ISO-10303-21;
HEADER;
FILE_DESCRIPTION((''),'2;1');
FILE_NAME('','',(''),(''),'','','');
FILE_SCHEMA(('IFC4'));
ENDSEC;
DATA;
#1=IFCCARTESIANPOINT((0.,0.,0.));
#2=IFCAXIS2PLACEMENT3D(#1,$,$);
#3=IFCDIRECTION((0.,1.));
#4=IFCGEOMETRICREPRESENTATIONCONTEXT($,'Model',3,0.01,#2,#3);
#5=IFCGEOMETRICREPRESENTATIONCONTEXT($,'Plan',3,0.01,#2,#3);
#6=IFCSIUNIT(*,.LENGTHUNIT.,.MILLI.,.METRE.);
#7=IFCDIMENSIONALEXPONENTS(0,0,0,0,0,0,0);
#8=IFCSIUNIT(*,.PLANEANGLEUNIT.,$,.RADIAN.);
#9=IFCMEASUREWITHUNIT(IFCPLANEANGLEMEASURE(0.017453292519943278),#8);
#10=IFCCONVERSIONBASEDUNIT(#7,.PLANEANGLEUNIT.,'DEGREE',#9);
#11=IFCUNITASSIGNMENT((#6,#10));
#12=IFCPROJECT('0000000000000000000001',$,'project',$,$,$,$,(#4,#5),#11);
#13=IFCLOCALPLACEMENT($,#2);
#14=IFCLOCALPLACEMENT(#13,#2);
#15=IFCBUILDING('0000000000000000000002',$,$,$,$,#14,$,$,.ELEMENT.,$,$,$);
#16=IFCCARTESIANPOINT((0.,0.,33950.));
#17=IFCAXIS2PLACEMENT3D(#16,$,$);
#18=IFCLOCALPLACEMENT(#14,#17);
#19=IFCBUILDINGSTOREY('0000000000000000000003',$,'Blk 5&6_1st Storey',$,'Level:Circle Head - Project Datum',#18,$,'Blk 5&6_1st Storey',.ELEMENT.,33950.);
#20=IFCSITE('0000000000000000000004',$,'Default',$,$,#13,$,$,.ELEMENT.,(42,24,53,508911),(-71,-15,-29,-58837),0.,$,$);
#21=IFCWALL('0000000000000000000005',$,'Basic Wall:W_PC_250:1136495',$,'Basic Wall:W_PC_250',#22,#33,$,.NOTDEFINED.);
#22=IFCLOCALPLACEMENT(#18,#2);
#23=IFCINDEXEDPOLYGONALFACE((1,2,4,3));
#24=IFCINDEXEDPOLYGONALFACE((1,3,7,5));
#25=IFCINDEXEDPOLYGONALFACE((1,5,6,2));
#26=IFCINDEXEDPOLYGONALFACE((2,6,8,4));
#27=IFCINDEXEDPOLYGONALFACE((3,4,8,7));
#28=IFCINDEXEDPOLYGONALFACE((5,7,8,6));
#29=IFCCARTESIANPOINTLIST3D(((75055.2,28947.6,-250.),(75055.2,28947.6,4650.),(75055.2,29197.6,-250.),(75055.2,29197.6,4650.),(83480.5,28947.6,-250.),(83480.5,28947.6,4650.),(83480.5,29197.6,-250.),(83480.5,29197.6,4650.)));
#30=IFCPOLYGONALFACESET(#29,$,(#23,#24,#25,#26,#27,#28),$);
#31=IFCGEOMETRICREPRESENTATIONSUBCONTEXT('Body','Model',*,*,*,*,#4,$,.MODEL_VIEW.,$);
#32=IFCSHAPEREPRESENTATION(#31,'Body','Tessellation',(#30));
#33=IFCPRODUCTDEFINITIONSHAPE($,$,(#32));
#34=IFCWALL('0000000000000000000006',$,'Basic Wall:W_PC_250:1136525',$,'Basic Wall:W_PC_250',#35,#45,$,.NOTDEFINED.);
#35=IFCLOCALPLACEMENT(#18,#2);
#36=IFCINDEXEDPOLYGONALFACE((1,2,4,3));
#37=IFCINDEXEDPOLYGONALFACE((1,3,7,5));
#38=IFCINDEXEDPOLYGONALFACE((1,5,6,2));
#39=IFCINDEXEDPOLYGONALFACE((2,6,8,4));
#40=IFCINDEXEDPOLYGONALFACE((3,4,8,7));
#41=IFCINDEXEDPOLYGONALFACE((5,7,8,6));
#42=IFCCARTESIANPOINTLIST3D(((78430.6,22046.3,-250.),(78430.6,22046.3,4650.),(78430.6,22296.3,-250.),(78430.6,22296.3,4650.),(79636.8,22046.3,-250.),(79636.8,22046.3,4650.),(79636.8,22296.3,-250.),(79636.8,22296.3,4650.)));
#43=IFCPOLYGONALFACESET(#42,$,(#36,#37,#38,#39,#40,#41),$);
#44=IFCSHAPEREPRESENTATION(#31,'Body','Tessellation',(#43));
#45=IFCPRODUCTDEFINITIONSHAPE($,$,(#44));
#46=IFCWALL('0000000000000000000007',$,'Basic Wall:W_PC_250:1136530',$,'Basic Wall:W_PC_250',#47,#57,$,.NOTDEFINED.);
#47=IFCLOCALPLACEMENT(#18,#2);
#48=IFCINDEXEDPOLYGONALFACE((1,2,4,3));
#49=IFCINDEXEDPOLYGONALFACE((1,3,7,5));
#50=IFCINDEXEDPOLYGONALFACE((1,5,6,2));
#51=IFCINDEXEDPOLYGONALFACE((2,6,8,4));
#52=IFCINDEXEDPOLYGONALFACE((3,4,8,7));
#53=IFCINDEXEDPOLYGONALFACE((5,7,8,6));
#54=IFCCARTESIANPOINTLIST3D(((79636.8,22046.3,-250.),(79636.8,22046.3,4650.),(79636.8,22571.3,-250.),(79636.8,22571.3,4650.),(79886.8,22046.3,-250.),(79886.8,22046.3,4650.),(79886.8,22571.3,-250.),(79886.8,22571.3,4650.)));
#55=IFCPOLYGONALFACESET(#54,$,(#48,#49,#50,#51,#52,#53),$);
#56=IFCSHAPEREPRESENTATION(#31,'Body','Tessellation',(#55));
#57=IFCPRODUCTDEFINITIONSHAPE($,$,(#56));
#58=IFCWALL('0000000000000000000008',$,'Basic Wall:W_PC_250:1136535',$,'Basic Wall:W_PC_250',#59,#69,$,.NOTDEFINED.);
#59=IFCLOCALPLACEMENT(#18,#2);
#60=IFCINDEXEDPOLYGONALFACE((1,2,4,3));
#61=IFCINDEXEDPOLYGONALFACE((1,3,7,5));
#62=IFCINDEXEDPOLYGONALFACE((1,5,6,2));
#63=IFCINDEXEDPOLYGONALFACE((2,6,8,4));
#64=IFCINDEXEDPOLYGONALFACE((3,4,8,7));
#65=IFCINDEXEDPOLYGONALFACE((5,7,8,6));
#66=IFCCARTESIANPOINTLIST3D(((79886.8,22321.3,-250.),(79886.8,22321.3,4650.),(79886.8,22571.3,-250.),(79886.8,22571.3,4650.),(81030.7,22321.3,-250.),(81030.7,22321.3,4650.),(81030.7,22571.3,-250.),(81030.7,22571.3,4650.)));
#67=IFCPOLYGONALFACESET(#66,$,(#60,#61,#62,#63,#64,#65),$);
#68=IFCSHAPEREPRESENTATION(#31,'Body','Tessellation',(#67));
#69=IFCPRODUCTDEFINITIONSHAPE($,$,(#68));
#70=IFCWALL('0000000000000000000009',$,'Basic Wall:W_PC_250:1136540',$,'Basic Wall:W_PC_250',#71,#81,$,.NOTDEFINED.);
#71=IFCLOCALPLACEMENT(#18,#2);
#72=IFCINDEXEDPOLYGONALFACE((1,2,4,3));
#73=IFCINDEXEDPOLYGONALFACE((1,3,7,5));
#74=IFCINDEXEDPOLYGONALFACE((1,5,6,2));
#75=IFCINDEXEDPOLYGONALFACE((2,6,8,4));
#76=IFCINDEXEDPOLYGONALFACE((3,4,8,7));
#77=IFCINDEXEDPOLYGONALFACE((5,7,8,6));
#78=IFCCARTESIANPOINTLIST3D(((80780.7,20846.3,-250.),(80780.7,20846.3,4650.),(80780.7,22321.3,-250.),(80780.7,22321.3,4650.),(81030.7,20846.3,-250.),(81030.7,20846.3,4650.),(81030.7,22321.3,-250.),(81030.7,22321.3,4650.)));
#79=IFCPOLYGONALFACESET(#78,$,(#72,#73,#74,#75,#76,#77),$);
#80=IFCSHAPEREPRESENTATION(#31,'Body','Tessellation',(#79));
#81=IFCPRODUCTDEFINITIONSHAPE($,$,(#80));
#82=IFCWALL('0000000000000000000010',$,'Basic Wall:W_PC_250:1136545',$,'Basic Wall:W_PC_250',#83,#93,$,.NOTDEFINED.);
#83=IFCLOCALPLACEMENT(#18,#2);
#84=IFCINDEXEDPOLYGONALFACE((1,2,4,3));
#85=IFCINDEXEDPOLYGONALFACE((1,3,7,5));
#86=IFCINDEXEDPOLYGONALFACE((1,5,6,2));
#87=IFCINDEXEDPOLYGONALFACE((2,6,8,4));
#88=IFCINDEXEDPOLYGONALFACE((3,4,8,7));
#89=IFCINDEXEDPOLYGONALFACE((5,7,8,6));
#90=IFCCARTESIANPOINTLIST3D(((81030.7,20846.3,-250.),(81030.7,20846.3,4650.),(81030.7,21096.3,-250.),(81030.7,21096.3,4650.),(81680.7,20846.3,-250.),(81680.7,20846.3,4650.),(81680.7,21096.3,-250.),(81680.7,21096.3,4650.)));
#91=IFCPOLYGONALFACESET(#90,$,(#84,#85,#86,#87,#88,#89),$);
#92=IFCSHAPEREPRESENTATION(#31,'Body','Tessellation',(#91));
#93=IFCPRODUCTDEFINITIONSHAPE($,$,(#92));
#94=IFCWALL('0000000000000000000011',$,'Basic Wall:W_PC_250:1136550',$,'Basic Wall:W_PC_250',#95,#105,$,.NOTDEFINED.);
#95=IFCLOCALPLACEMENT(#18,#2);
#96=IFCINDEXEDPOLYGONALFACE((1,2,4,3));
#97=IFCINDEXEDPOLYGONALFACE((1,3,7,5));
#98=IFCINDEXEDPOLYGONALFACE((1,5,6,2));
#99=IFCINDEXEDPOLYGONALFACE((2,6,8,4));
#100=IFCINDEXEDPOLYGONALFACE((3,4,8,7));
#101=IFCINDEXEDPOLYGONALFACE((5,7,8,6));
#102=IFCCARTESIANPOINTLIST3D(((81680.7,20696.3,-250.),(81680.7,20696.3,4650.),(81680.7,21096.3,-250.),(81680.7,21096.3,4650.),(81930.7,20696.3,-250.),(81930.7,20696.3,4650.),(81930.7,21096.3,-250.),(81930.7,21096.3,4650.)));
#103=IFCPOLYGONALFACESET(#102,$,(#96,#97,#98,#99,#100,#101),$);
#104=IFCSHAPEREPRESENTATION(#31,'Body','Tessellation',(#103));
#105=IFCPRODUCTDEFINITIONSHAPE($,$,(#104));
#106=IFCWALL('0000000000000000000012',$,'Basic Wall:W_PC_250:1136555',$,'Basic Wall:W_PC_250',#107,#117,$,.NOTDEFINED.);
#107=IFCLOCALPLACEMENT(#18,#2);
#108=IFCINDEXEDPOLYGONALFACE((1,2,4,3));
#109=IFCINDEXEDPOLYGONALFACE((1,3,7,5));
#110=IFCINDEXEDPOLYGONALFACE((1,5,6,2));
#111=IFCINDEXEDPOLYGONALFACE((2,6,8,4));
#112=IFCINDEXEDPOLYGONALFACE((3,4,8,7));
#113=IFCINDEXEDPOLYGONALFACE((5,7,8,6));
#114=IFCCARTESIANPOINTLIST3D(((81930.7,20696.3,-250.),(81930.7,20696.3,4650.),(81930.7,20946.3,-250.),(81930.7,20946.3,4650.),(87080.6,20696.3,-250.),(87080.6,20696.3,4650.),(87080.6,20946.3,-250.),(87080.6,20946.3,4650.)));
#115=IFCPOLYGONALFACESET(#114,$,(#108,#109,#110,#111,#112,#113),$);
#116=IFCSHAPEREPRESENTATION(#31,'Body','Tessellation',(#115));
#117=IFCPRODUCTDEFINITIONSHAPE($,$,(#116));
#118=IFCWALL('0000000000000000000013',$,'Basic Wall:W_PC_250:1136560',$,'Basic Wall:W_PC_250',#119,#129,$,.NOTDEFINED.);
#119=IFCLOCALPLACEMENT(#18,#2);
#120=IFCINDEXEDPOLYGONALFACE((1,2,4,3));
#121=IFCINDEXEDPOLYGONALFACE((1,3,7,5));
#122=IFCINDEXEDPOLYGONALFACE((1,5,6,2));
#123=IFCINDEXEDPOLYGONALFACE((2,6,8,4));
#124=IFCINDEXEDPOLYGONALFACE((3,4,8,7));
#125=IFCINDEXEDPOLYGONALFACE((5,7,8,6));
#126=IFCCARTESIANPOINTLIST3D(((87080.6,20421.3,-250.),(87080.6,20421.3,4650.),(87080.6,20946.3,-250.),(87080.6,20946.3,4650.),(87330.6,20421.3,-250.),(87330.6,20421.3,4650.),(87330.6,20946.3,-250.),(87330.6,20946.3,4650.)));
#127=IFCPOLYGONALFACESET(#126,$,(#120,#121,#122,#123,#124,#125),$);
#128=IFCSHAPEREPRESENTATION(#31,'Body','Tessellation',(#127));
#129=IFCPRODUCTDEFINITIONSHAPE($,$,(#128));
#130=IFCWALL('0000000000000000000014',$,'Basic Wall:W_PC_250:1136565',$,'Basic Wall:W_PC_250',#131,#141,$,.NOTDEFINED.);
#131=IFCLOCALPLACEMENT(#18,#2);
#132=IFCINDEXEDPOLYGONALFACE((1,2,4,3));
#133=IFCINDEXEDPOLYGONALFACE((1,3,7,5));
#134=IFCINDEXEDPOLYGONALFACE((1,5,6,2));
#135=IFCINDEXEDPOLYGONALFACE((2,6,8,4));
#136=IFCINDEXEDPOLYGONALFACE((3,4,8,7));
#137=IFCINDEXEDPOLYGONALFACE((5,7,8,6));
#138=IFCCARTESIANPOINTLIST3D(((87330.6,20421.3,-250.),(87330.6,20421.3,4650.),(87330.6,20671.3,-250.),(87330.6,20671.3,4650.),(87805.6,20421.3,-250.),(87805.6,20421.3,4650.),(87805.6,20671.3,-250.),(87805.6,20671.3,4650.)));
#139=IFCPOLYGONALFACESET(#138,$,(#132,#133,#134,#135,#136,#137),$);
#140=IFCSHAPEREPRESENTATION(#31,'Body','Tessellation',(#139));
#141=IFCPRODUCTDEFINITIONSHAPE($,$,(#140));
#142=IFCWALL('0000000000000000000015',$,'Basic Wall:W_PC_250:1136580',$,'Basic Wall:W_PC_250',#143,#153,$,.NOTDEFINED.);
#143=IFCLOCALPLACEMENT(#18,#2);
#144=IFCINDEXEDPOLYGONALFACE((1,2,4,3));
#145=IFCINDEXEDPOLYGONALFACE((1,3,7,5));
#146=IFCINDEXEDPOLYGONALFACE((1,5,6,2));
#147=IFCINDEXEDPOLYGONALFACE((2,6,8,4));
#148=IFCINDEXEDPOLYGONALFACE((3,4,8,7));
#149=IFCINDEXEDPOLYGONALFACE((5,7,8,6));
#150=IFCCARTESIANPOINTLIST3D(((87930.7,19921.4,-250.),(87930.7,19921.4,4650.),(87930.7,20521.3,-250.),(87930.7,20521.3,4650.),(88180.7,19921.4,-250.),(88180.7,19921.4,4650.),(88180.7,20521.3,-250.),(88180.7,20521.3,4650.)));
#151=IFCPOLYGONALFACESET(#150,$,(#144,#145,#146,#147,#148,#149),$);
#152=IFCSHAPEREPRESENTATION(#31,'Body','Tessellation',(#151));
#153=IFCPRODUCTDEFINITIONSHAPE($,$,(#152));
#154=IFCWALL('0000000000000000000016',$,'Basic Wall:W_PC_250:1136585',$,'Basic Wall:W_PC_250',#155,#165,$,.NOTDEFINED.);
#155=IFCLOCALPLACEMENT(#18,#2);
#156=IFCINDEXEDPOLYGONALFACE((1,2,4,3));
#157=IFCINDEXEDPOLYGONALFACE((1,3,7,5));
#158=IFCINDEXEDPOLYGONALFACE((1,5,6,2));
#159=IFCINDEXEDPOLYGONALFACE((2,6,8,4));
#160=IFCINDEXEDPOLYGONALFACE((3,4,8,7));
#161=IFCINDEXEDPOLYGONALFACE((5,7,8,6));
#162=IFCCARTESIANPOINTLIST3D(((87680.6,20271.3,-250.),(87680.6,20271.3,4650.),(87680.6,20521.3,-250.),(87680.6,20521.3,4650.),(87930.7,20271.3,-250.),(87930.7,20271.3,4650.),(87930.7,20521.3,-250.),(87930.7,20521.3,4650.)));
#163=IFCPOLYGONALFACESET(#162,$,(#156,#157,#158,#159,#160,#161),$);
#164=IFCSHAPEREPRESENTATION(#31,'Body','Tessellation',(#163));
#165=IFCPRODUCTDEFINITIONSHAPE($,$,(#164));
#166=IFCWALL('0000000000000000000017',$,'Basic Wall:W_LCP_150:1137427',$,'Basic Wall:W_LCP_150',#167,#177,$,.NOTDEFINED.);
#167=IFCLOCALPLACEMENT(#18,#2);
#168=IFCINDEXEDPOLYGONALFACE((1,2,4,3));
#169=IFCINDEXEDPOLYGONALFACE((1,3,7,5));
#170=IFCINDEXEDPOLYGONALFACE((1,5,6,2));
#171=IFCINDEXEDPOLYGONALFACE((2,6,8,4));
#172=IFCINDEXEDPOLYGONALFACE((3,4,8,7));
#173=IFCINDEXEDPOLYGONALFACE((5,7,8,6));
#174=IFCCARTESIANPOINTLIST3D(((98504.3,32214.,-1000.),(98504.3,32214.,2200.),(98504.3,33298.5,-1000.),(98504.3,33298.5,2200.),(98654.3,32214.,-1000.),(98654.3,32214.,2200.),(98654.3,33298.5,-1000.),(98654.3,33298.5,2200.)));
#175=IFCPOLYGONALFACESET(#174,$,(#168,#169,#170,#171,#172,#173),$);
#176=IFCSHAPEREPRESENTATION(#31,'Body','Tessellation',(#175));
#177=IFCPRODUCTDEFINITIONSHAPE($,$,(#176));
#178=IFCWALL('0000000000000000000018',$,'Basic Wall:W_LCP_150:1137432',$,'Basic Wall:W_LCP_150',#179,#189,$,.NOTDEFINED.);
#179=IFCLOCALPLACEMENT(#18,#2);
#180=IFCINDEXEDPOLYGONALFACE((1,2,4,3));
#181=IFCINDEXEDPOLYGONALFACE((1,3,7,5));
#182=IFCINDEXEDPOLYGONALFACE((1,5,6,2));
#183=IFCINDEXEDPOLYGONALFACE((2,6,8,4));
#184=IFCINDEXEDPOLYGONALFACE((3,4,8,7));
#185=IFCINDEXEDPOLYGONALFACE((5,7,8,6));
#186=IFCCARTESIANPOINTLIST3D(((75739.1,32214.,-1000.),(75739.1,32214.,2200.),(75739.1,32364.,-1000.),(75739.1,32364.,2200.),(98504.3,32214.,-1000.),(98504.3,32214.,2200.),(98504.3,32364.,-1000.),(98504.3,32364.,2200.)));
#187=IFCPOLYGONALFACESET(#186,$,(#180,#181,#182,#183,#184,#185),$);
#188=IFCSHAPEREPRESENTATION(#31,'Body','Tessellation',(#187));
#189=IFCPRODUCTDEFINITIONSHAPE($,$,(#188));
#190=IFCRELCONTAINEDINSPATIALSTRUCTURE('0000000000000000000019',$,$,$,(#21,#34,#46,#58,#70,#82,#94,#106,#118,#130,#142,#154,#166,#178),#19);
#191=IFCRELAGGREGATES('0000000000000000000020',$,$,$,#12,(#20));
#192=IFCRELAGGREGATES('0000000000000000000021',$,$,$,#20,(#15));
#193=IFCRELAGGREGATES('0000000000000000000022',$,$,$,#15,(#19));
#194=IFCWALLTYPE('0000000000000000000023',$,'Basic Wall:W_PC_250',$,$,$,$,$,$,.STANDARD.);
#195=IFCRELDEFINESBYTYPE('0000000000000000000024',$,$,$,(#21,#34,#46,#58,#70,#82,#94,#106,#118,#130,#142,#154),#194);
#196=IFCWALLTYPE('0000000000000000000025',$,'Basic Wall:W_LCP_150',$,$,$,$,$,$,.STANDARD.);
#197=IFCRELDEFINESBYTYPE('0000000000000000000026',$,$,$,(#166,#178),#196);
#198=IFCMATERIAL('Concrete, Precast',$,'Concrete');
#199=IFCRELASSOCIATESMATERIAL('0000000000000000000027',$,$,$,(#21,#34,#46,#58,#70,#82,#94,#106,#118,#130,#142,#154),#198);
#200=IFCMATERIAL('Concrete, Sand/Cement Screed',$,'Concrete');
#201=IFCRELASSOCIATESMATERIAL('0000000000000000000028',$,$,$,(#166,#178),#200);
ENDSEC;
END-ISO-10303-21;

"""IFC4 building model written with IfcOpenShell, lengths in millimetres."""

from ifc_helpers import new_model, entity, si_unit, converted_unit, direction, frame, origin, place, context, subcontext, project, spatial, indexed_curve, outline, extrude, material, type_object, element, save


model = new_model("IFC4")

# Units and contexts
model_context = context("Model", 3, precision=0.01, world=origin(), true_north=direction((0.0, 1.0)))
plan_context = context("Plan", 3, precision=0.01, world=origin(), true_north=direction((0.0, 1.0)))
body_context = subcontext(model_context, "Body", "Model", "MODEL_VIEW")
ifc_project = project(units=[si_unit("LENGTHUNIT", "METRE", prefix="MILLI"), converted_unit("PLANEANGLEUNIT", "DEGREE", entity("IfcPlaneAngleMeasure", 0.017453292519943278), si_unit("PLANEANGLEUNIT", "RADIAN"), dimensions=[0, 0, 0, 0, 0, 0, 0])], contexts=[model_context, plan_context])

# Site, building, storey
site_placement = place(None, origin())
site = spatial("IfcSite", under=ifc_project, at=site_placement, Name="Default", CompositionType="ELEMENT", RefLatitude=(42, 24, 53, 508911), RefLongitude=(-71, -15, -29, -58837), RefElevation=0.0)
building_placement = place(site_placement, origin())
building = spatial("IfcBuilding", under=site, at=building_placement, CompositionType="ELEMENT")
storey_placement = place(building_placement, frame((0.0, 0.0, 33950.0)))
storey = spatial("IfcBuildingStorey", under=building, at=storey_placement, Name="Blk 5&6_1st Storey", ObjectType="Level:Circle Head - Project Datum", LongName="Blk 5&6_1st Storey", CompositionType="ELEMENT", Elevation=33950.0)

# Walls
ifc_material_1 = material(Name="Concrete, Precast", Category="Concrete")
wall_type_1 = type_object("IfcWallType", Name="Basic Wall:W_PC_250", PredefinedType="STANDARD")
wall_1_placement = place(storey_placement, frame((83480.5, 29072.6, -250.0), z_axis=(0.0, 0.0, 1.0), x_axis=(-1.0, 0.0, 0.0)))
element("IfcWall", 1, at=wall_1_placement, inside=storey, type_object=wall_type_1, material=ifc_material_1, Name="Basic Wall:W_PC_250:1136495", ObjectType="Basic Wall:W_PC_250", PredefinedType="NOTDEFINED", context=body_context, shape_type="SweptSolid", body=[
    extrude(outline(indexed_curve([(8425.3, 125.0), (0.0, 125.0), (0.0, -125.0), (8425.3, -125.0), (8425.3, 125.0)], self_intersect=False)), origin(), (0.0, 0.0, 1.0), 4900.0),
])
wall_2_placement = place(storey_placement, frame((78430.6, 22171.3, -250.0)))
element("IfcWall", 2, at=wall_2_placement, inside=storey, type_object=wall_type_1, material=ifc_material_1, Name="Basic Wall:W_PC_250:1136525", ObjectType="Basic Wall:W_PC_250", PredefinedType="NOTDEFINED", context=body_context, shape_type="SweptSolid", body=[
    extrude(outline(indexed_curve([(1206.2, 125.0), (0.0, 125.0), (0.0, -125.0), (1206.2, -125.0), (1206.2, 125.0)], self_intersect=False)), origin(), (0.0, 0.0, 1.0), 4900.0),
])
wall_3_placement = place(storey_placement, frame((79761.8, 22046.3, -250.0), z_axis=(0.0, 0.0, 1.0), x_axis=(0.0, 1.0, 0.0)))
element("IfcWall", 3, at=wall_3_placement, inside=storey, type_object=wall_type_1, material=ifc_material_1, Name="Basic Wall:W_PC_250:1136530", ObjectType="Basic Wall:W_PC_250", PredefinedType="NOTDEFINED", context=body_context, shape_type="SweptSolid", body=[
    extrude(outline(indexed_curve([(525.0, 125.0), (0.0, 125.0), (0.0, -125.0), (525.0, -125.0), (525.0, 125.0)], self_intersect=False)), origin(), (0.0, 0.0, 1.0), 4900.0),
])
wall_4_placement = place(storey_placement, frame((79886.8, 22446.3, -250.0)))
element("IfcWall", 4, at=wall_4_placement, inside=storey, type_object=wall_type_1, material=ifc_material_1, Name="Basic Wall:W_PC_250:1136535", ObjectType="Basic Wall:W_PC_250", PredefinedType="NOTDEFINED", context=body_context, shape_type="SweptSolid", body=[
    extrude(outline(indexed_curve([(1143.9, 125.0), (0.0, 125.0), (0.0, -125.0), (1143.9, -125.0), (1143.9, 125.0)], self_intersect=False)), origin(), (0.0, 0.0, 1.0), 4900.0),
])
wall_5_placement = place(storey_placement, frame((80905.7, 22321.3, -250.0), z_axis=(0.0, 0.0, 1.0), x_axis=(0.0, -1.0, 0.0)))
element("IfcWall", 5, at=wall_5_placement, inside=storey, type_object=wall_type_1, material=ifc_material_1, Name="Basic Wall:W_PC_250:1136540", ObjectType="Basic Wall:W_PC_250", PredefinedType="NOTDEFINED", context=body_context, shape_type="SweptSolid", body=[
    extrude(outline(indexed_curve([(1475.0, 125.0), (0.0, 125.0), (0.0, -125.0), (1475.0, -125.0), (1475.0, 125.0)], self_intersect=False)), origin(), (0.0, 0.0, 1.0), 4900.0),
])
wall_6_placement = place(storey_placement, frame((81030.7, 20971.3, -250.0)))
element("IfcWall", 6, at=wall_6_placement, inside=storey, type_object=wall_type_1, material=ifc_material_1, Name="Basic Wall:W_PC_250:1136545", ObjectType="Basic Wall:W_PC_250", PredefinedType="NOTDEFINED", context=body_context, shape_type="SweptSolid", body=[
    extrude(outline(indexed_curve([(650.0, 125.0), (0.0, 125.0), (0.0, -125.0), (650.0, -125.0), (650.0, 125.0)], self_intersect=False)), origin(), (0.0, 0.0, 1.0), 4900.0),
])
wall_7_placement = place(storey_placement, frame((81805.7, 21096.3, -250.0), z_axis=(0.0, 0.0, 1.0), x_axis=(0.0, -1.0, 0.0)))
element("IfcWall", 7, at=wall_7_placement, inside=storey, type_object=wall_type_1, material=ifc_material_1, Name="Basic Wall:W_PC_250:1136550", ObjectType="Basic Wall:W_PC_250", PredefinedType="NOTDEFINED", context=body_context, shape_type="SweptSolid", body=[
    extrude(outline(indexed_curve([(400.0, 125.0), (0.0, 125.0), (0.0, -125.0), (400.0, -125.0), (400.0, 125.0)], self_intersect=False)), origin(), (0.0, 0.0, 1.0), 4900.0),
])
wall_8_placement = place(storey_placement, frame((81930.7, 20821.3, -250.0)))
element("IfcWall", 8, at=wall_8_placement, inside=storey, type_object=wall_type_1, material=ifc_material_1, Name="Basic Wall:W_PC_250:1136555", ObjectType="Basic Wall:W_PC_250", PredefinedType="NOTDEFINED", context=body_context, shape_type="SweptSolid", body=[
    extrude(outline(indexed_curve([(5149.9, 125.0), (0.0, 125.0), (0.0, -125.0), (5149.9, -125.0), (5149.9, 125.0)], self_intersect=False)), origin(), (0.0, 0.0, 1.0), 4900.0),
])
wall_9_placement = place(storey_placement, frame((87205.6, 20946.3, -250.0), z_axis=(0.0, 0.0, 1.0), x_axis=(0.0, -1.0, 0.0)))
element("IfcWall", 9, at=wall_9_placement, inside=storey, type_object=wall_type_1, material=ifc_material_1, Name="Basic Wall:W_PC_250:1136560", ObjectType="Basic Wall:W_PC_250", PredefinedType="NOTDEFINED", context=body_context, shape_type="SweptSolid", body=[
    extrude(outline(indexed_curve([(525.0, 125.0), (0.0, 125.0), (0.0, -125.0), (525.0, -125.0), (525.0, 125.0)], self_intersect=False)), origin(), (0.0, 0.0, 1.0), 4900.0),
])
wall_10_placement = place(storey_placement, frame((87330.6, 20546.3, -250.0)))
element("IfcWall", 10, at=wall_10_placement, inside=storey, type_object=wall_type_1, material=ifc_material_1, Name="Basic Wall:W_PC_250:1136565", ObjectType="Basic Wall:W_PC_250", PredefinedType="NOTDEFINED", context=body_context, shape_type="SweptSolid", body=[
    extrude(outline(indexed_curve([(475.0, 125.0), (0.0, 125.0), (0.0, -125.0), (475.0, -125.0), (475.0, 125.0)], self_intersect=False)), origin(), (0.0, 0.0, 1.0), 4900.0),
])
wall_11_placement = place(storey_placement, frame((88055.7, 20521.3, -250.0), z_axis=(0.0, 0.0, 1.0), x_axis=(0.0, -1.0, 0.0)))
element("IfcWall", 11, at=wall_11_placement, inside=storey, type_object=wall_type_1, material=ifc_material_1, Name="Basic Wall:W_PC_250:1136580", ObjectType="Basic Wall:W_PC_250", PredefinedType="NOTDEFINED", context=body_context, shape_type="SweptSolid", body=[
    extrude(outline(indexed_curve([(599.9, 125.0), (0.0, 125.0), (0.0, -125.0), (599.9, -125.0), (599.9, 125.0)], self_intersect=False)), origin(), (0.0, 0.0, 1.0), 4900.0),
])
wall_12_placement = place(storey_placement, frame((87680.6, 20396.3, -250.0)))
element("IfcWall", 12, at=wall_12_placement, inside=storey, type_object=wall_type_1, material=ifc_material_1, Name="Basic Wall:W_PC_250:1136585", ObjectType="Basic Wall:W_PC_250", PredefinedType="NOTDEFINED", context=body_context, shape_type="SweptSolid", body=[
    extrude(outline(indexed_curve([(250.1, 125.0), (0.0, 125.0), (0.0, -125.0), (250.1, -125.0), (250.1, 125.0)], self_intersect=False)), origin(), (0.0, 0.0, 1.0), 4900.0),
])
ifc_material_2 = material(Name="Concrete, Sand/Cement Screed", Category="Concrete")
wall_type_2 = type_object("IfcWallType", Name="Basic Wall:W_LCP_150", PredefinedType="STANDARD")
wall_13_placement = place(storey_placement, frame((98579.3, 33298.5, -1000.0), z_axis=(0.0, 0.0, 1.0), x_axis=(0.0, -1.0, 0.0)))
element("IfcWall", 13, at=wall_13_placement, inside=storey, type_object=wall_type_2, material=ifc_material_2, Name="Basic Wall:W_LCP_150:1137427", ObjectType="Basic Wall:W_LCP_150", PredefinedType="NOTDEFINED", context=body_context, shape_type="SweptSolid", body=[
    extrude(outline(indexed_curve([(1084.5, 75.0), (0.0, 75.0), (0.0, -75.0), (1084.5, -75.0), (1084.5, 75.0)], self_intersect=False)), origin(), (0.0, 0.0, 1.0), 3200.0),
])
wall_14_placement = place(storey_placement, frame((98504.3, 32289.0, -1000.0), z_axis=(0.0, 0.0, 1.0), x_axis=(-1.0, 0.0, 0.0)))
element("IfcWall", 14, at=wall_14_placement, inside=storey, type_object=wall_type_2, material=ifc_material_2, Name="Basic Wall:W_LCP_150:1137432", ObjectType="Basic Wall:W_LCP_150", PredefinedType="NOTDEFINED", context=body_context, shape_type="SweptSolid", body=[
    extrude(outline(indexed_curve([(22765.2, 75.0), (0.0, 75.0), (0.0, -75.0), (22765.2, -75.0), (22765.2, 75.0)], self_intersect=False)), origin(), (0.0, 0.0, 1.0), 3200.0),
])

save(model, "model.ifc")
